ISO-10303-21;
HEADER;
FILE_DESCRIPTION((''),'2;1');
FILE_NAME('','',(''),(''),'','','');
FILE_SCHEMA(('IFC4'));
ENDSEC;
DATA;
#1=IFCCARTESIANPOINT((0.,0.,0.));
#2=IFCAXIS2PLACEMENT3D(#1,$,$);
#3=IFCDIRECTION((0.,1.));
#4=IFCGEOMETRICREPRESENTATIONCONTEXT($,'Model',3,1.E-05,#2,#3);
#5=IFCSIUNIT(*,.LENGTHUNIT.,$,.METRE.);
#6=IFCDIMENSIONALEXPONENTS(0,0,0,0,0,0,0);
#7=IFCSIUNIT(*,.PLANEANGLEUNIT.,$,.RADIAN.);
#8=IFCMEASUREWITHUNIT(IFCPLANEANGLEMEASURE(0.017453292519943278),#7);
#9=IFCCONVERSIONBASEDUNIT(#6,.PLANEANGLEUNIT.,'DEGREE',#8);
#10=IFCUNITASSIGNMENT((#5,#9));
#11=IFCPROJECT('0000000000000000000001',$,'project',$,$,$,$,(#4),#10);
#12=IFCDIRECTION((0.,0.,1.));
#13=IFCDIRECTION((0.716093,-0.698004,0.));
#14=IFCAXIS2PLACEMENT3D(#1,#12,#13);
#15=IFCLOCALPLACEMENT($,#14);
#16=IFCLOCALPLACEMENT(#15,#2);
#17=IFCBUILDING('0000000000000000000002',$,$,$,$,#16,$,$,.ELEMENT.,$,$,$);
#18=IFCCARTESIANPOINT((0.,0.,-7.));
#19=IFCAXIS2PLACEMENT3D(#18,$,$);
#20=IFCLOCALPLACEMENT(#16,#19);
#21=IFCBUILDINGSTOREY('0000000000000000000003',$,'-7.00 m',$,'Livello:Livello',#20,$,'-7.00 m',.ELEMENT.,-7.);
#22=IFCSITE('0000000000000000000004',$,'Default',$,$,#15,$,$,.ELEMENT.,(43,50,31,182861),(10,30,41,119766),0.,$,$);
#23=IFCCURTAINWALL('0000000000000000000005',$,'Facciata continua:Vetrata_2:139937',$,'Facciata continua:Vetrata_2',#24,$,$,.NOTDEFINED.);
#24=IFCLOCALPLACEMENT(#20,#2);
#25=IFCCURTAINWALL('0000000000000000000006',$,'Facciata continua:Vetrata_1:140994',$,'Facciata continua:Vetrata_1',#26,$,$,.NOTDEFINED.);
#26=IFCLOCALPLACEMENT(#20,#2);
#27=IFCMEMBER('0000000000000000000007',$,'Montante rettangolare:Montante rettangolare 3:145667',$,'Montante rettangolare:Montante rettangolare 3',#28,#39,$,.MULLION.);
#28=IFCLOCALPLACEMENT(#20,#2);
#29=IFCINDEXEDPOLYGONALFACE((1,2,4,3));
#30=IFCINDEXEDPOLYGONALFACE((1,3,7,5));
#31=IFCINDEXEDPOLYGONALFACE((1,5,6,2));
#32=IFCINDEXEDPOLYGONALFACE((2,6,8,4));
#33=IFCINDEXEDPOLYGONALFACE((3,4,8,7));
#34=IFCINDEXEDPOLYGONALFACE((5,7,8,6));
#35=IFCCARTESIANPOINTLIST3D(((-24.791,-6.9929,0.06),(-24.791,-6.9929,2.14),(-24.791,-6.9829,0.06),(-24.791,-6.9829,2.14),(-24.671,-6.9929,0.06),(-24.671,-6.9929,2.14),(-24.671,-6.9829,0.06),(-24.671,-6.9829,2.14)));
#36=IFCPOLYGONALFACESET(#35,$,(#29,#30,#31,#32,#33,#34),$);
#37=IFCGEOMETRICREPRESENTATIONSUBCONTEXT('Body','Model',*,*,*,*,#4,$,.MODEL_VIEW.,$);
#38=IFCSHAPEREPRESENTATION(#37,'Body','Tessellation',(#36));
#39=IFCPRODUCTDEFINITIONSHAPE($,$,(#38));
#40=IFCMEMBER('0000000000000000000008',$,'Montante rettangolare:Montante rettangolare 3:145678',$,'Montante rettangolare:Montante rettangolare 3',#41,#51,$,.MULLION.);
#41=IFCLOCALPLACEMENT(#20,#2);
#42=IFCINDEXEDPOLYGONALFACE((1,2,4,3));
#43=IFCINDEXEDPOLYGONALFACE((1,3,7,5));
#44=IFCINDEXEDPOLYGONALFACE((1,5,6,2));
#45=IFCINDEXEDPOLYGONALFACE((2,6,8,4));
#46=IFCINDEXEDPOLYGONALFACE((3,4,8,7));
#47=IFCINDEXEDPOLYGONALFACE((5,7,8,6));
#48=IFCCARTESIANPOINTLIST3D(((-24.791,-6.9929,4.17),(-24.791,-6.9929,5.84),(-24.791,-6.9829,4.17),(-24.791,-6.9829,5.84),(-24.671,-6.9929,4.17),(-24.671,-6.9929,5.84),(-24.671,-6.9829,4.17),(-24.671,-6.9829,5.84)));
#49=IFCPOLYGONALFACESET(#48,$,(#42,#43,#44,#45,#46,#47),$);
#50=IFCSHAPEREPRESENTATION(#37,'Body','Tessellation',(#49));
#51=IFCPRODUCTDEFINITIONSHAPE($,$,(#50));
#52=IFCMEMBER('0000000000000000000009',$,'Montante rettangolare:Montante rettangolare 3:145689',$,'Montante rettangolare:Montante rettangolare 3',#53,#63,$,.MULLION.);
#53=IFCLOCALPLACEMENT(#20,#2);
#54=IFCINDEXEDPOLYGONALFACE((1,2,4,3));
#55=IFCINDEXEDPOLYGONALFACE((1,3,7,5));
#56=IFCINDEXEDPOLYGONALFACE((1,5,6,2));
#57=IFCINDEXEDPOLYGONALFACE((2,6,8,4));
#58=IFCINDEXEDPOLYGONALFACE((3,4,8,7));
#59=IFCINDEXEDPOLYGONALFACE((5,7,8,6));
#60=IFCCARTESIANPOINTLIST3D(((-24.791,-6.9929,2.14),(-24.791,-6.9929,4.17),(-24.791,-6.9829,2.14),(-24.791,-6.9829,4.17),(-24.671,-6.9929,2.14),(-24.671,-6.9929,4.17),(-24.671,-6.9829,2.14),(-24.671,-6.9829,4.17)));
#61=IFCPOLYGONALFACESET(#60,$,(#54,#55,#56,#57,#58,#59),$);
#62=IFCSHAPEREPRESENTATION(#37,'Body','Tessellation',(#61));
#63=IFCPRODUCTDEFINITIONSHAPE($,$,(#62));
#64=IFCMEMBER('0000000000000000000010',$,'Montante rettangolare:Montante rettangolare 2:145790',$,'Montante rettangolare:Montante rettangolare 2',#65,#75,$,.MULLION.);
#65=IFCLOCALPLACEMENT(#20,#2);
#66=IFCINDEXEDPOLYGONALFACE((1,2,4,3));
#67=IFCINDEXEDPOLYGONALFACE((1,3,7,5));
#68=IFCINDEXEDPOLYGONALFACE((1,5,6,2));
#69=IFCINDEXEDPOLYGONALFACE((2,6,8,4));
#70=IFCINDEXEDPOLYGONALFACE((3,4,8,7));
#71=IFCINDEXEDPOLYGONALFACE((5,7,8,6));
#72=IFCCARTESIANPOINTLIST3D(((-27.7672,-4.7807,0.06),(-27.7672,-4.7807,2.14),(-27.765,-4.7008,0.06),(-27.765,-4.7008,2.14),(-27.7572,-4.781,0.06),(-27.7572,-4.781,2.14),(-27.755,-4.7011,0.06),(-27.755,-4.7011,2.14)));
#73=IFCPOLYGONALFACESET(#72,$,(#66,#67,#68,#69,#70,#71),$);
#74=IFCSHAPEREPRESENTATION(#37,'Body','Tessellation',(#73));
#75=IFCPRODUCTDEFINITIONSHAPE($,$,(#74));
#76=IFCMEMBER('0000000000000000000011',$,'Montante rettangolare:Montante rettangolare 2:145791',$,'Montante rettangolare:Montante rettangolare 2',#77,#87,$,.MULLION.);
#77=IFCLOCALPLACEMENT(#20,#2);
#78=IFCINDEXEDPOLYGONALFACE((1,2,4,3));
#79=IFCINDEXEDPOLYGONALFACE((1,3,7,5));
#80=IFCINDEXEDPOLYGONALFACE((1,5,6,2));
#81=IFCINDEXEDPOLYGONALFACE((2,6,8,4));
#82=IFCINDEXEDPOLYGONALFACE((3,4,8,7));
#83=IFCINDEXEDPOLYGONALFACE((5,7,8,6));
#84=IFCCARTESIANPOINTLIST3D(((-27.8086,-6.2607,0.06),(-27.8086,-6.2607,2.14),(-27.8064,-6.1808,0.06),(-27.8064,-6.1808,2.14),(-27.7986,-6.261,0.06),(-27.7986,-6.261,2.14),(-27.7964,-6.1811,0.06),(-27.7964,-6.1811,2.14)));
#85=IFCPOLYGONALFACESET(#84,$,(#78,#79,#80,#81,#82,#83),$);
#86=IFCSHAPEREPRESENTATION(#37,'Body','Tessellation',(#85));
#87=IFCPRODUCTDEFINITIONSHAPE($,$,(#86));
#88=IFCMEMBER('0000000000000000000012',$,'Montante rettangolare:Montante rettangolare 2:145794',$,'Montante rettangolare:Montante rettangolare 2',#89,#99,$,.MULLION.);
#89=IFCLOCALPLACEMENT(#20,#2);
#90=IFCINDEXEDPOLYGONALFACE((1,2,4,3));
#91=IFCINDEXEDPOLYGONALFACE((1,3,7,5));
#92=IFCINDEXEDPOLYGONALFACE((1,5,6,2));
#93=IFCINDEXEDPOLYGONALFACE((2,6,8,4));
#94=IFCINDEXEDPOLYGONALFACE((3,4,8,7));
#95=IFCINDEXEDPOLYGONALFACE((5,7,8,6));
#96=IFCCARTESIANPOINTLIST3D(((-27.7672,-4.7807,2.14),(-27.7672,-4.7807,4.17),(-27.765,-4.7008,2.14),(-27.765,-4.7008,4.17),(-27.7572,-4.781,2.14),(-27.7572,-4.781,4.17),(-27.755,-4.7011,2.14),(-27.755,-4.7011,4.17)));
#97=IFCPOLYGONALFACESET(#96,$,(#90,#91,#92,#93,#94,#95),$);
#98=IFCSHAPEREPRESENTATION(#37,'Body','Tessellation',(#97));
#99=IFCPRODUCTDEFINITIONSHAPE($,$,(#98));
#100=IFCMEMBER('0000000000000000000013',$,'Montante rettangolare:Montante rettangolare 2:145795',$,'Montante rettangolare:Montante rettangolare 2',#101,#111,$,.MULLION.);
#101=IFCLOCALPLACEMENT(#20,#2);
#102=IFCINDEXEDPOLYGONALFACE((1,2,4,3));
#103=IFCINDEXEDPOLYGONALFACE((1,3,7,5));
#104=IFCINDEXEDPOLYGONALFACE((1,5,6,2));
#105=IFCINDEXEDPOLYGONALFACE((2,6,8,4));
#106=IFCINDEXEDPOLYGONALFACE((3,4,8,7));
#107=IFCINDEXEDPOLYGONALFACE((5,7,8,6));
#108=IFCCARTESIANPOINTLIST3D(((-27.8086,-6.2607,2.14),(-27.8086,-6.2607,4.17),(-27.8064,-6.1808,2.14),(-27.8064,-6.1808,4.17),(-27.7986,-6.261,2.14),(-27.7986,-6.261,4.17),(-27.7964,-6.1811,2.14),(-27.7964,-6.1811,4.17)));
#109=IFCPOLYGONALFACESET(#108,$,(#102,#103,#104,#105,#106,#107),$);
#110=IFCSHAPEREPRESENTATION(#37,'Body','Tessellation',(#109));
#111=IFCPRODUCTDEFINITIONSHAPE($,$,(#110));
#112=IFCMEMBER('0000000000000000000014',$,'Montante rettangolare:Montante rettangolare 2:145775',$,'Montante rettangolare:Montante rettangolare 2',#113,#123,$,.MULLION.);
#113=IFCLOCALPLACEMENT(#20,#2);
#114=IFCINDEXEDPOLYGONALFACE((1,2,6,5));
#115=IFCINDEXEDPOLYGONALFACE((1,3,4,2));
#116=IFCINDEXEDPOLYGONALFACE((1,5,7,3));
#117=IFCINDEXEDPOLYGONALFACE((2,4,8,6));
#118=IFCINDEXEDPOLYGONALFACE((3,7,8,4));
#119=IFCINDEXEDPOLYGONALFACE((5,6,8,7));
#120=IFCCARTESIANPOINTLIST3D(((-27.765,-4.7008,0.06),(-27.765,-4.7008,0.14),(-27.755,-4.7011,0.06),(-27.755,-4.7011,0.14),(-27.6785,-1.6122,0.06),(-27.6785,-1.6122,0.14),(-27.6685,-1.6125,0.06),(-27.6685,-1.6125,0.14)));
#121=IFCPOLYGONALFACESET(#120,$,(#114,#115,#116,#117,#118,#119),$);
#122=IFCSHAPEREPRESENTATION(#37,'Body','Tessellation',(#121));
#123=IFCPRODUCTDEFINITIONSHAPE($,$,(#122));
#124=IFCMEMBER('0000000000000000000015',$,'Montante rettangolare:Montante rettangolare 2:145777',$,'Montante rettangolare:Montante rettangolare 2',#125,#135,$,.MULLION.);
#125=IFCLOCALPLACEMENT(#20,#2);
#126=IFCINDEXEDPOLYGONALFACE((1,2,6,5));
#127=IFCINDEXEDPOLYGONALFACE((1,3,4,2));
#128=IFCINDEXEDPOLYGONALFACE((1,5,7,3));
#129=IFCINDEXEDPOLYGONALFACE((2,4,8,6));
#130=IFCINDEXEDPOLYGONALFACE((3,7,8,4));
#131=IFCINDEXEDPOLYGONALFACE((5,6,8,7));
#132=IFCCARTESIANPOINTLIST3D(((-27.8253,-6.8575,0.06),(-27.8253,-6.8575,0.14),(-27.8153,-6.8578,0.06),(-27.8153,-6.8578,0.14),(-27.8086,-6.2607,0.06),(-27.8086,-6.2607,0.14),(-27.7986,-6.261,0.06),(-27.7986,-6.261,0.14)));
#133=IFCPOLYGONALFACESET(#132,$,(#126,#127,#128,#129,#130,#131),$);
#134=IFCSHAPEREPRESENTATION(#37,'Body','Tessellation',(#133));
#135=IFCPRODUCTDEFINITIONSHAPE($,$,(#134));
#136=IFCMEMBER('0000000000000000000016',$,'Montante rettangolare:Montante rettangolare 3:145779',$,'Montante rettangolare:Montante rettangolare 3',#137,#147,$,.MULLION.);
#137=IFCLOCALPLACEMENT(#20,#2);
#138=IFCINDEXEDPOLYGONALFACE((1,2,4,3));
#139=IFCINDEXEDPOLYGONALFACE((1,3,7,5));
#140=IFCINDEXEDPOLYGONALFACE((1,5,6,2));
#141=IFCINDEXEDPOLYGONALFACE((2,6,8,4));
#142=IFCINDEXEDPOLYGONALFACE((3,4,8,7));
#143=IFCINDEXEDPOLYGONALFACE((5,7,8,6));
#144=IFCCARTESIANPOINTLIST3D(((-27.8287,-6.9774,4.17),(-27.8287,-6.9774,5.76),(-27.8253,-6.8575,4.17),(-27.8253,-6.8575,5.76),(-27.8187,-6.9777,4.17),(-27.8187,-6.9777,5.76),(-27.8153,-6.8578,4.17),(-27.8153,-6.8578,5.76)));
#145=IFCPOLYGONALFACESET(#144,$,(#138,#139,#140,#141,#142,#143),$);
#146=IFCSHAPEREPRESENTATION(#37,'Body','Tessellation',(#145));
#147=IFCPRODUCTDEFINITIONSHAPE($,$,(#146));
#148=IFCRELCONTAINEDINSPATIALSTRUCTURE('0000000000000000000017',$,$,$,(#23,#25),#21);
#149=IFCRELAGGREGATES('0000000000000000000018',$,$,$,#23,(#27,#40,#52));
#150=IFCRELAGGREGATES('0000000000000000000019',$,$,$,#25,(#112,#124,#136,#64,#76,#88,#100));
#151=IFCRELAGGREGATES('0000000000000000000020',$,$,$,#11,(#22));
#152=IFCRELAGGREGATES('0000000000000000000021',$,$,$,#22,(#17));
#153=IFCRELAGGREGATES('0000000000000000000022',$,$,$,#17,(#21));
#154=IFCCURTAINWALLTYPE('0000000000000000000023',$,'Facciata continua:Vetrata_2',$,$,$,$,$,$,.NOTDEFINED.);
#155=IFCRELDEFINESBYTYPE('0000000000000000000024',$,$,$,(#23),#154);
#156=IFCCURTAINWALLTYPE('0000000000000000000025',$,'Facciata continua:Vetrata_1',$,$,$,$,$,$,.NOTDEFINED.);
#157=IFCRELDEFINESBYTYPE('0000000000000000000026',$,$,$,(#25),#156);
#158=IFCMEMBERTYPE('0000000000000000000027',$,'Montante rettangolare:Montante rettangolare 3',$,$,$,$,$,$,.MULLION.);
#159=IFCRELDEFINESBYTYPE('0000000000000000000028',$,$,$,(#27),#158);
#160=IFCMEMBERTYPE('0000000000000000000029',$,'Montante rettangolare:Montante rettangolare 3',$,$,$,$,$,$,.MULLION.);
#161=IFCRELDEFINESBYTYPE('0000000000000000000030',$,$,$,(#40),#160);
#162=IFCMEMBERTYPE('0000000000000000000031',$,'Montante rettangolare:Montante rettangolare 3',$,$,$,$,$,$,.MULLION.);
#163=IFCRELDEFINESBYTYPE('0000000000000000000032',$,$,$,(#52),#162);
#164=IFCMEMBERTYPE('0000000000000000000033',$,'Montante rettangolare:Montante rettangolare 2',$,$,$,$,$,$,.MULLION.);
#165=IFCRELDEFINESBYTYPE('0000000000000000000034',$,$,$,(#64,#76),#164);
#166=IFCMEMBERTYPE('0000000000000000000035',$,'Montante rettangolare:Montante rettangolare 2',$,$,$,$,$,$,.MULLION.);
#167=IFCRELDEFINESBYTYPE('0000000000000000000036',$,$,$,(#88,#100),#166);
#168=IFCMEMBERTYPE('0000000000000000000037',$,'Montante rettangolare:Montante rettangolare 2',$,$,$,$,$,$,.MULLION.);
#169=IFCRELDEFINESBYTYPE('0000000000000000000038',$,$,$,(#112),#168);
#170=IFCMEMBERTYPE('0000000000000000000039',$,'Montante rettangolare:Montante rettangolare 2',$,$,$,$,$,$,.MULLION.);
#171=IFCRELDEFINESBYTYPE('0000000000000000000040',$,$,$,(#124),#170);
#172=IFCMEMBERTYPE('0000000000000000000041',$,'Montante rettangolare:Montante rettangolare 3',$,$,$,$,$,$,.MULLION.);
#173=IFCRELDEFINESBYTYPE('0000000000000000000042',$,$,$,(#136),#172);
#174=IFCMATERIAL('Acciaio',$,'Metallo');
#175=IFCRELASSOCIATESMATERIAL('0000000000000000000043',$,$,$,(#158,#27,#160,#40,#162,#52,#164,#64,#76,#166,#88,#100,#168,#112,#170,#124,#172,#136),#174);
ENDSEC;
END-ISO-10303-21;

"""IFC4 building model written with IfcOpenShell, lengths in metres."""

from ifc_helpers import new_model, entity, si_unit, converted_unit, direction, frame, origin, place, context, subcontext, project, spatial, indexed_curve, outline, extrude, source, transform, mapped, material, type_object, type_shapes, element, aggregate, save


model = new_model("IFC4")

# Units and contexts
model_context = context("Model", 3, precision=1e-05, world=origin(), true_north=direction((0.0, 1.0)))
body_context = subcontext(model_context, "Body", "Model", "MODEL_VIEW")
ifc_project = project(units=[si_unit("LENGTHUNIT", "METRE"), converted_unit("PLANEANGLEUNIT", "DEGREE", entity("IfcPlaneAngleMeasure", 0.017453292519943278), si_unit("PLANEANGLEUNIT", "RADIAN"), dimensions=[0, 0, 0, 0, 0, 0, 0])], contexts=[model_context])

# Site, building, storey
site_placement = place(None, frame((0.0, 0.0, 0.0), z_axis=(0.0, 0.0, 1.0), x_axis=(0.716093, -0.698004, 0.0)))
site = spatial("IfcSite", under=ifc_project, at=site_placement, Name="Default", CompositionType="ELEMENT", RefLatitude=(43, 50, 31, 182861), RefLongitude=(10, 30, 41, 119766), RefElevation=0.0)
building_placement = place(site_placement, origin())
building = spatial("IfcBuilding", under=site, at=building_placement, CompositionType="ELEMENT")
storey_placement = place(building_placement, frame((0.0, 0.0, -7.0)))
storey = spatial("IfcBuildingStorey", under=building, at=storey_placement, Name="-7.00 m", ObjectType="Livello:Livello", LongName="-7.00 m", CompositionType="ELEMENT", Elevation=-7.0)

# Curtain walls
curtain_wall_type_1 = type_object("IfcCurtainWallType", Name="Facciata continua:Vetrata_2", PredefinedType="NOTDEFINED")
curtain_wall_1_placement = place(storey_placement, frame((0.0, 0.0, 7.0)))
curtain_wall_1 = element("IfcCurtainWall", 1, at=curtain_wall_1_placement, inside=storey, type_object=curtain_wall_type_1, Name="Facciata continua:Vetrata_2:139937", ObjectType="Facciata continua:Vetrata_2", PredefinedType="NOTDEFINED")
ifc_material_1 = material(Name="Acciaio", Category="Metallo")
curtain_wall_type_2 = type_object("IfcCurtainWallType", Name="Facciata continua:Vetrata_1", PredefinedType="NOTDEFINED")
curtain_wall_2_placement = place(storey_placement, frame((0.0, 0.0, 7.0)))
curtain_wall_2 = element("IfcCurtainWall", 2, at=curtain_wall_2_placement, inside=storey, type_object=curtain_wall_type_2, Name="Facciata continua:Vetrata_1:140994", ObjectType="Facciata continua:Vetrata_1", PredefinedType="NOTDEFINED")

# Members
member_type_1 = type_object("IfcMemberType", Name="Montante rettangolare:Montante rettangolare 3", PredefinedType="MULLION", material=ifc_material_1)
shared_shape_1 = source(origin(), body_context, "Body", "SweptSolid", [
    extrude(outline(indexed_curve([(-0.06, -0.005), (0.06, -0.005), (0.06, 0.005), (-0.06, 0.005), (-0.06, -0.005)], self_intersect=False)), frame((0.0, 0.01, -2.08), z_axis=(0.0, 0.0, 1.0), x_axis=(-1.0, 0.0, 0.0)), (0.0, 0.0, 1.0), 2.08),
])
type_shapes(member_type_1, [shared_shape_1])
member_1_placement = place(curtain_wall_1_placement, frame((-24.731, -6.9779, -6.94), z_axis=(0.0, 0.0, -1.0), x_axis=(1.0, 0.0, 0.0)))
member_1 = element("IfcMember", 3, at=member_1_placement, type_object=member_type_1, material=ifc_material_1, Name="Montante rettangolare:Montante rettangolare 3:145667", ObjectType="Montante rettangolare:Montante rettangolare 3", PredefinedType="MULLION", context=body_context, shape_type="MappedRepresentation", body=[
    mapped(shared_shape_1, transform((0.0, 0.0, 0.0), scale=1.0)),
])
member_type_2 = type_object("IfcMemberType", Name="Montante rettangolare:Montante rettangolare 3", PredefinedType="MULLION", material=ifc_material_1)
shared_shape_2 = source(origin(), body_context, "Body", "SweptSolid", [
    extrude(outline(indexed_curve([(-0.06, -0.005), (0.06, -0.005), (0.06, 0.005), (-0.06, 0.005), (-0.06, -0.005)], self_intersect=False)), frame((0.0, 0.01, -1.67), z_axis=(0.0, 0.0, 1.0), x_axis=(-1.0, 0.0, 0.0)), (0.0, 0.0, 1.0), 1.67),
])
type_shapes(member_type_2, [shared_shape_2])
member_2_placement = place(curtain_wall_1_placement, frame((-24.731, -6.9779, -2.83), z_axis=(0.0, 0.0, -1.0), x_axis=(1.0, 0.0, 0.0)))
member_2 = element("IfcMember", 4, at=member_2_placement, type_object=member_type_2, material=ifc_material_1, Name="Montante rettangolare:Montante rettangolare 3:145678", ObjectType="Montante rettangolare:Montante rettangolare 3", PredefinedType="MULLION", context=body_context, shape_type="MappedRepresentation", body=[
    mapped(shared_shape_2, transform((0.0, 0.0, 0.0), scale=1.0)),
])
member_type_3 = type_object("IfcMemberType", Name="Montante rettangolare:Montante rettangolare 3", PredefinedType="MULLION", material=ifc_material_1)
shared_shape_3 = source(origin(), body_context, "Body", "SweptSolid", [
    extrude(outline(indexed_curve([(-0.06, -0.005), (0.06, -0.005), (0.06, 0.005), (-0.06, 0.005), (-0.06, -0.005)], self_intersect=False)), frame((0.0, 0.01, -2.03), z_axis=(0.0, 0.0, 1.0), x_axis=(-1.0, 0.0, 0.0)), (0.0, 0.0, 1.0), 2.03),
])
type_shapes(member_type_3, [shared_shape_3])
member_3_placement = place(curtain_wall_1_placement, frame((-24.731, -6.9779, -4.86), z_axis=(0.0, 0.0, -1.0), x_axis=(1.0, 0.0, 0.0)))
member_3 = element("IfcMember", 5, at=member_3_placement, type_object=member_type_3, material=ifc_material_1, Name="Montante rettangolare:Montante rettangolare 3:145689", ObjectType="Montante rettangolare:Montante rettangolare 3", PredefinedType="MULLION", context=body_context, shape_type="MappedRepresentation", body=[
    mapped(shared_shape_3, transform((0.0, 0.0, 0.0), scale=1.0)),
])
aggregate(curtain_wall_1, [member_1, member_2, member_3])
member_type_4 = type_object("IfcMemberType", Name="Montante rettangolare:Montante rettangolare 2", PredefinedType="MULLION", material=ifc_material_1)
shared_shape_4 = source(origin(), body_context, "Body", "SweptSolid", [
    extrude(outline(indexed_curve([(-0.04, -0.005), (0.04, -0.005), (0.04, 0.005), (-0.04, 0.005), (-0.04, -0.005)], self_intersect=False)), frame((0.0, 0.01, -2.08), z_axis=(0.0, 0.0, 1.0), x_axis=(-1.0, 0.0, 0.0)), (0.0, 0.0, 1.0), 2.08),
])
type_shapes(member_type_4, [shared_shape_4])
member_4_placement = place(curtain_wall_2_placement, frame((-27.7511, -4.7412, -6.94), z_axis=(0.0, 0.0, -1.0), x_axis=(-0.02798, -0.999608, 0.0)))
member_4 = element("IfcMember", 6, at=member_4_placement, type_object=member_type_4, material=ifc_material_1, Name="Montante rettangolare:Montante rettangolare 2:145790", ObjectType="Montante rettangolare:Montante rettangolare 2", PredefinedType="MULLION", context=body_context, shape_type="MappedRepresentation", body=[
    mapped(shared_shape_4, transform((0.0, 0.0, 0.0), scale=1.0)),
])
member_5_placement = place(curtain_wall_2_placement, frame((-27.7925, -6.2212, -6.94), z_axis=(0.0, 0.0, -1.0), x_axis=(-0.02798, -0.999608, 0.0)))
member_5 = element("IfcMember", 7, at=member_5_placement, type_object=member_type_4, material=ifc_material_1, Name="Montante rettangolare:Montante rettangolare 2:145791", ObjectType="Montante rettangolare:Montante rettangolare 2", PredefinedType="MULLION", context=body_context, shape_type="MappedRepresentation", body=[
    mapped(shared_shape_4, transform((0.0, 0.0, 0.0), scale=1.0)),
])
member_type_5 = type_object("IfcMemberType", Name="Montante rettangolare:Montante rettangolare 2", PredefinedType="MULLION", material=ifc_material_1)
shared_shape_5 = source(origin(), body_context, "Body", "SweptSolid", [
    extrude(outline(indexed_curve([(-0.04, -0.005), (0.04, -0.005), (0.04, 0.005), (-0.04, 0.005), (-0.04, -0.005)], self_intersect=False)), frame((0.0, 0.01, -2.03), z_axis=(0.0, 0.0, 1.0), x_axis=(-1.0, 0.0, 0.0)), (0.0, 0.0, 1.0), 2.03),
])
type_shapes(member_type_5, [shared_shape_5])
member_6_placement = place(curtain_wall_2_placement, frame((-27.7511, -4.7412, -4.86), z_axis=(0.0, 0.0, -1.0), x_axis=(-0.02798, -0.999608, 0.0)))
member_6 = element("IfcMember", 8, at=member_6_placement, type_object=member_type_5, material=ifc_material_1, Name="Montante rettangolare:Montante rettangolare 2:145794", ObjectType="Montante rettangolare:Montante rettangolare 2", PredefinedType="MULLION", context=body_context, shape_type="MappedRepresentation", body=[
    mapped(shared_shape_5, transform((0.0, 0.0, 0.0), scale=1.0)),
])
member_7_placement = place(curtain_wall_2_placement, frame((-27.7925, -6.2212, -4.86), z_axis=(0.0, 0.0, -1.0), x_axis=(-0.02798, -0.999608, 0.0)))
member_7 = element("IfcMember", 9, at=member_7_placement, type_object=member_type_5, material=ifc_material_1, Name="Montante rettangolare:Montante rettangolare 2:145795", ObjectType="Montante rettangolare:Montante rettangolare 2", PredefinedType="MULLION", context=body_context, shape_type="MappedRepresentation", body=[
    mapped(shared_shape_5, transform((0.0, 0.0, 0.0), scale=1.0)),
])
member_type_6 = type_object("IfcMemberType", Name="Montante rettangolare:Montante rettangolare 2", PredefinedType="MULLION", material=ifc_material_1)
shared_shape_6 = source(origin(), body_context, "Body", "SweptSolid", [
    extrude(outline(indexed_curve([(-0.04, -0.005), (0.04, -0.005), (0.04, 0.005), (-0.04, 0.005), (-0.04, -0.005)], self_intersect=False)), frame((-0.04, 0.01, -3.0898), z_axis=(0.0, 0.0, 1.0), x_axis=(-1.0, 0.0, 0.0)), (0.0, 0.0, 1.0), 3.0898),
])
type_shapes(member_type_6, [shared_shape_6])
member_8_placement = place(curtain_wall_2_placement, frame((-27.6635, -1.6126, -6.94), z_axis=(0.02798, 0.999608, 0.0), x_axis=(0.0, 0.0, -1.0)))
member_8 = element("IfcMember", 10, at=member_8_placement, type_object=member_type_6, material=ifc_material_1, Name="Montante rettangolare:Montante rettangolare 2:145775", ObjectType="Montante rettangolare:Montante rettangolare 2", PredefinedType="MULLION", context=body_context, shape_type="MappedRepresentation", body=[
    mapped(shared_shape_6, transform((0.0, 0.0, 0.0), scale=1.0)),
])
member_type_7 = type_object("IfcMemberType", Name="Montante rettangolare:Montante rettangolare 2", PredefinedType="MULLION", material=ifc_material_1)
shared_shape_7 = source(origin(), body_context, "Body", "SweptSolid", [
    extrude(outline(indexed_curve([(-0.04, -0.005), (0.04, -0.005), (0.04, 0.005), (-0.04, 0.005), (-0.04, -0.005)], self_intersect=False)), frame((-0.04, 0.01, -0.597), z_axis=(0.0, 0.0, 1.0), x_axis=(-1.0, 0.0, 0.0)), (0.0, 0.0, 1.0), 0.597),
])
type_shapes(member_type_7, [shared_shape_7])
member_9_placement = place(curtain_wall_2_placement, frame((-27.7936, -6.2612, -6.94), z_axis=(0.02798, 0.999608, 0.0), x_axis=(0.0, 0.0, -1.0)))
member_9 = element("IfcMember", 11, at=member_9_placement, type_object=member_type_7, material=ifc_material_1, Name="Montante rettangolare:Montante rettangolare 2:145777", ObjectType="Montante rettangolare:Montante rettangolare 2", PredefinedType="MULLION", context=body_context, shape_type="MappedRepresentation", body=[
    mapped(shared_shape_7, transform((0.0, 0.0, 0.0), scale=1.0)),
])
member_type_8 = type_object("IfcMemberType", Name="Montante rettangolare:Montante rettangolare 3", PredefinedType="MULLION", material=ifc_material_1)
shared_shape_8 = source(origin(), body_context, "Body", "SweptSolid", [
    extrude(outline(indexed_curve([(-0.06, -0.005), (0.06, -0.005), (0.06, 0.005), (-0.06, 0.005), (-0.06, -0.005)], self_intersect=False)), frame((-0.06, 0.01, -1.59), z_axis=(0.0, 0.0, 1.0), x_axis=(-1.0, 0.0, 0.0)), (0.0, 0.0, 1.0), 1.59),
])
type_shapes(member_type_8, [shared_shape_8])
member_10_placement = place(curtain_wall_2_placement, frame((-27.8137, -6.9779, -2.83), z_axis=(0.0, 0.0, -1.0), x_axis=(-0.02798, -0.999608, 0.0)))
member_10 = element("IfcMember", 12, at=member_10_placement, type_object=member_type_8, material=ifc_material_1, Name="Montante rettangolare:Montante rettangolare 3:145779", ObjectType="Montante rettangolare:Montante rettangolare 3", PredefinedType="MULLION", context=body_context, shape_type="MappedRepresentation", body=[
    mapped(shared_shape_8, transform((0.0, 0.0, 0.0), scale=1.0)),
])

aggregate(curtain_wall_2, [member_8, member_9, member_10, member_4, member_5, member_6, member_7])

save(model, "model.ifc")
